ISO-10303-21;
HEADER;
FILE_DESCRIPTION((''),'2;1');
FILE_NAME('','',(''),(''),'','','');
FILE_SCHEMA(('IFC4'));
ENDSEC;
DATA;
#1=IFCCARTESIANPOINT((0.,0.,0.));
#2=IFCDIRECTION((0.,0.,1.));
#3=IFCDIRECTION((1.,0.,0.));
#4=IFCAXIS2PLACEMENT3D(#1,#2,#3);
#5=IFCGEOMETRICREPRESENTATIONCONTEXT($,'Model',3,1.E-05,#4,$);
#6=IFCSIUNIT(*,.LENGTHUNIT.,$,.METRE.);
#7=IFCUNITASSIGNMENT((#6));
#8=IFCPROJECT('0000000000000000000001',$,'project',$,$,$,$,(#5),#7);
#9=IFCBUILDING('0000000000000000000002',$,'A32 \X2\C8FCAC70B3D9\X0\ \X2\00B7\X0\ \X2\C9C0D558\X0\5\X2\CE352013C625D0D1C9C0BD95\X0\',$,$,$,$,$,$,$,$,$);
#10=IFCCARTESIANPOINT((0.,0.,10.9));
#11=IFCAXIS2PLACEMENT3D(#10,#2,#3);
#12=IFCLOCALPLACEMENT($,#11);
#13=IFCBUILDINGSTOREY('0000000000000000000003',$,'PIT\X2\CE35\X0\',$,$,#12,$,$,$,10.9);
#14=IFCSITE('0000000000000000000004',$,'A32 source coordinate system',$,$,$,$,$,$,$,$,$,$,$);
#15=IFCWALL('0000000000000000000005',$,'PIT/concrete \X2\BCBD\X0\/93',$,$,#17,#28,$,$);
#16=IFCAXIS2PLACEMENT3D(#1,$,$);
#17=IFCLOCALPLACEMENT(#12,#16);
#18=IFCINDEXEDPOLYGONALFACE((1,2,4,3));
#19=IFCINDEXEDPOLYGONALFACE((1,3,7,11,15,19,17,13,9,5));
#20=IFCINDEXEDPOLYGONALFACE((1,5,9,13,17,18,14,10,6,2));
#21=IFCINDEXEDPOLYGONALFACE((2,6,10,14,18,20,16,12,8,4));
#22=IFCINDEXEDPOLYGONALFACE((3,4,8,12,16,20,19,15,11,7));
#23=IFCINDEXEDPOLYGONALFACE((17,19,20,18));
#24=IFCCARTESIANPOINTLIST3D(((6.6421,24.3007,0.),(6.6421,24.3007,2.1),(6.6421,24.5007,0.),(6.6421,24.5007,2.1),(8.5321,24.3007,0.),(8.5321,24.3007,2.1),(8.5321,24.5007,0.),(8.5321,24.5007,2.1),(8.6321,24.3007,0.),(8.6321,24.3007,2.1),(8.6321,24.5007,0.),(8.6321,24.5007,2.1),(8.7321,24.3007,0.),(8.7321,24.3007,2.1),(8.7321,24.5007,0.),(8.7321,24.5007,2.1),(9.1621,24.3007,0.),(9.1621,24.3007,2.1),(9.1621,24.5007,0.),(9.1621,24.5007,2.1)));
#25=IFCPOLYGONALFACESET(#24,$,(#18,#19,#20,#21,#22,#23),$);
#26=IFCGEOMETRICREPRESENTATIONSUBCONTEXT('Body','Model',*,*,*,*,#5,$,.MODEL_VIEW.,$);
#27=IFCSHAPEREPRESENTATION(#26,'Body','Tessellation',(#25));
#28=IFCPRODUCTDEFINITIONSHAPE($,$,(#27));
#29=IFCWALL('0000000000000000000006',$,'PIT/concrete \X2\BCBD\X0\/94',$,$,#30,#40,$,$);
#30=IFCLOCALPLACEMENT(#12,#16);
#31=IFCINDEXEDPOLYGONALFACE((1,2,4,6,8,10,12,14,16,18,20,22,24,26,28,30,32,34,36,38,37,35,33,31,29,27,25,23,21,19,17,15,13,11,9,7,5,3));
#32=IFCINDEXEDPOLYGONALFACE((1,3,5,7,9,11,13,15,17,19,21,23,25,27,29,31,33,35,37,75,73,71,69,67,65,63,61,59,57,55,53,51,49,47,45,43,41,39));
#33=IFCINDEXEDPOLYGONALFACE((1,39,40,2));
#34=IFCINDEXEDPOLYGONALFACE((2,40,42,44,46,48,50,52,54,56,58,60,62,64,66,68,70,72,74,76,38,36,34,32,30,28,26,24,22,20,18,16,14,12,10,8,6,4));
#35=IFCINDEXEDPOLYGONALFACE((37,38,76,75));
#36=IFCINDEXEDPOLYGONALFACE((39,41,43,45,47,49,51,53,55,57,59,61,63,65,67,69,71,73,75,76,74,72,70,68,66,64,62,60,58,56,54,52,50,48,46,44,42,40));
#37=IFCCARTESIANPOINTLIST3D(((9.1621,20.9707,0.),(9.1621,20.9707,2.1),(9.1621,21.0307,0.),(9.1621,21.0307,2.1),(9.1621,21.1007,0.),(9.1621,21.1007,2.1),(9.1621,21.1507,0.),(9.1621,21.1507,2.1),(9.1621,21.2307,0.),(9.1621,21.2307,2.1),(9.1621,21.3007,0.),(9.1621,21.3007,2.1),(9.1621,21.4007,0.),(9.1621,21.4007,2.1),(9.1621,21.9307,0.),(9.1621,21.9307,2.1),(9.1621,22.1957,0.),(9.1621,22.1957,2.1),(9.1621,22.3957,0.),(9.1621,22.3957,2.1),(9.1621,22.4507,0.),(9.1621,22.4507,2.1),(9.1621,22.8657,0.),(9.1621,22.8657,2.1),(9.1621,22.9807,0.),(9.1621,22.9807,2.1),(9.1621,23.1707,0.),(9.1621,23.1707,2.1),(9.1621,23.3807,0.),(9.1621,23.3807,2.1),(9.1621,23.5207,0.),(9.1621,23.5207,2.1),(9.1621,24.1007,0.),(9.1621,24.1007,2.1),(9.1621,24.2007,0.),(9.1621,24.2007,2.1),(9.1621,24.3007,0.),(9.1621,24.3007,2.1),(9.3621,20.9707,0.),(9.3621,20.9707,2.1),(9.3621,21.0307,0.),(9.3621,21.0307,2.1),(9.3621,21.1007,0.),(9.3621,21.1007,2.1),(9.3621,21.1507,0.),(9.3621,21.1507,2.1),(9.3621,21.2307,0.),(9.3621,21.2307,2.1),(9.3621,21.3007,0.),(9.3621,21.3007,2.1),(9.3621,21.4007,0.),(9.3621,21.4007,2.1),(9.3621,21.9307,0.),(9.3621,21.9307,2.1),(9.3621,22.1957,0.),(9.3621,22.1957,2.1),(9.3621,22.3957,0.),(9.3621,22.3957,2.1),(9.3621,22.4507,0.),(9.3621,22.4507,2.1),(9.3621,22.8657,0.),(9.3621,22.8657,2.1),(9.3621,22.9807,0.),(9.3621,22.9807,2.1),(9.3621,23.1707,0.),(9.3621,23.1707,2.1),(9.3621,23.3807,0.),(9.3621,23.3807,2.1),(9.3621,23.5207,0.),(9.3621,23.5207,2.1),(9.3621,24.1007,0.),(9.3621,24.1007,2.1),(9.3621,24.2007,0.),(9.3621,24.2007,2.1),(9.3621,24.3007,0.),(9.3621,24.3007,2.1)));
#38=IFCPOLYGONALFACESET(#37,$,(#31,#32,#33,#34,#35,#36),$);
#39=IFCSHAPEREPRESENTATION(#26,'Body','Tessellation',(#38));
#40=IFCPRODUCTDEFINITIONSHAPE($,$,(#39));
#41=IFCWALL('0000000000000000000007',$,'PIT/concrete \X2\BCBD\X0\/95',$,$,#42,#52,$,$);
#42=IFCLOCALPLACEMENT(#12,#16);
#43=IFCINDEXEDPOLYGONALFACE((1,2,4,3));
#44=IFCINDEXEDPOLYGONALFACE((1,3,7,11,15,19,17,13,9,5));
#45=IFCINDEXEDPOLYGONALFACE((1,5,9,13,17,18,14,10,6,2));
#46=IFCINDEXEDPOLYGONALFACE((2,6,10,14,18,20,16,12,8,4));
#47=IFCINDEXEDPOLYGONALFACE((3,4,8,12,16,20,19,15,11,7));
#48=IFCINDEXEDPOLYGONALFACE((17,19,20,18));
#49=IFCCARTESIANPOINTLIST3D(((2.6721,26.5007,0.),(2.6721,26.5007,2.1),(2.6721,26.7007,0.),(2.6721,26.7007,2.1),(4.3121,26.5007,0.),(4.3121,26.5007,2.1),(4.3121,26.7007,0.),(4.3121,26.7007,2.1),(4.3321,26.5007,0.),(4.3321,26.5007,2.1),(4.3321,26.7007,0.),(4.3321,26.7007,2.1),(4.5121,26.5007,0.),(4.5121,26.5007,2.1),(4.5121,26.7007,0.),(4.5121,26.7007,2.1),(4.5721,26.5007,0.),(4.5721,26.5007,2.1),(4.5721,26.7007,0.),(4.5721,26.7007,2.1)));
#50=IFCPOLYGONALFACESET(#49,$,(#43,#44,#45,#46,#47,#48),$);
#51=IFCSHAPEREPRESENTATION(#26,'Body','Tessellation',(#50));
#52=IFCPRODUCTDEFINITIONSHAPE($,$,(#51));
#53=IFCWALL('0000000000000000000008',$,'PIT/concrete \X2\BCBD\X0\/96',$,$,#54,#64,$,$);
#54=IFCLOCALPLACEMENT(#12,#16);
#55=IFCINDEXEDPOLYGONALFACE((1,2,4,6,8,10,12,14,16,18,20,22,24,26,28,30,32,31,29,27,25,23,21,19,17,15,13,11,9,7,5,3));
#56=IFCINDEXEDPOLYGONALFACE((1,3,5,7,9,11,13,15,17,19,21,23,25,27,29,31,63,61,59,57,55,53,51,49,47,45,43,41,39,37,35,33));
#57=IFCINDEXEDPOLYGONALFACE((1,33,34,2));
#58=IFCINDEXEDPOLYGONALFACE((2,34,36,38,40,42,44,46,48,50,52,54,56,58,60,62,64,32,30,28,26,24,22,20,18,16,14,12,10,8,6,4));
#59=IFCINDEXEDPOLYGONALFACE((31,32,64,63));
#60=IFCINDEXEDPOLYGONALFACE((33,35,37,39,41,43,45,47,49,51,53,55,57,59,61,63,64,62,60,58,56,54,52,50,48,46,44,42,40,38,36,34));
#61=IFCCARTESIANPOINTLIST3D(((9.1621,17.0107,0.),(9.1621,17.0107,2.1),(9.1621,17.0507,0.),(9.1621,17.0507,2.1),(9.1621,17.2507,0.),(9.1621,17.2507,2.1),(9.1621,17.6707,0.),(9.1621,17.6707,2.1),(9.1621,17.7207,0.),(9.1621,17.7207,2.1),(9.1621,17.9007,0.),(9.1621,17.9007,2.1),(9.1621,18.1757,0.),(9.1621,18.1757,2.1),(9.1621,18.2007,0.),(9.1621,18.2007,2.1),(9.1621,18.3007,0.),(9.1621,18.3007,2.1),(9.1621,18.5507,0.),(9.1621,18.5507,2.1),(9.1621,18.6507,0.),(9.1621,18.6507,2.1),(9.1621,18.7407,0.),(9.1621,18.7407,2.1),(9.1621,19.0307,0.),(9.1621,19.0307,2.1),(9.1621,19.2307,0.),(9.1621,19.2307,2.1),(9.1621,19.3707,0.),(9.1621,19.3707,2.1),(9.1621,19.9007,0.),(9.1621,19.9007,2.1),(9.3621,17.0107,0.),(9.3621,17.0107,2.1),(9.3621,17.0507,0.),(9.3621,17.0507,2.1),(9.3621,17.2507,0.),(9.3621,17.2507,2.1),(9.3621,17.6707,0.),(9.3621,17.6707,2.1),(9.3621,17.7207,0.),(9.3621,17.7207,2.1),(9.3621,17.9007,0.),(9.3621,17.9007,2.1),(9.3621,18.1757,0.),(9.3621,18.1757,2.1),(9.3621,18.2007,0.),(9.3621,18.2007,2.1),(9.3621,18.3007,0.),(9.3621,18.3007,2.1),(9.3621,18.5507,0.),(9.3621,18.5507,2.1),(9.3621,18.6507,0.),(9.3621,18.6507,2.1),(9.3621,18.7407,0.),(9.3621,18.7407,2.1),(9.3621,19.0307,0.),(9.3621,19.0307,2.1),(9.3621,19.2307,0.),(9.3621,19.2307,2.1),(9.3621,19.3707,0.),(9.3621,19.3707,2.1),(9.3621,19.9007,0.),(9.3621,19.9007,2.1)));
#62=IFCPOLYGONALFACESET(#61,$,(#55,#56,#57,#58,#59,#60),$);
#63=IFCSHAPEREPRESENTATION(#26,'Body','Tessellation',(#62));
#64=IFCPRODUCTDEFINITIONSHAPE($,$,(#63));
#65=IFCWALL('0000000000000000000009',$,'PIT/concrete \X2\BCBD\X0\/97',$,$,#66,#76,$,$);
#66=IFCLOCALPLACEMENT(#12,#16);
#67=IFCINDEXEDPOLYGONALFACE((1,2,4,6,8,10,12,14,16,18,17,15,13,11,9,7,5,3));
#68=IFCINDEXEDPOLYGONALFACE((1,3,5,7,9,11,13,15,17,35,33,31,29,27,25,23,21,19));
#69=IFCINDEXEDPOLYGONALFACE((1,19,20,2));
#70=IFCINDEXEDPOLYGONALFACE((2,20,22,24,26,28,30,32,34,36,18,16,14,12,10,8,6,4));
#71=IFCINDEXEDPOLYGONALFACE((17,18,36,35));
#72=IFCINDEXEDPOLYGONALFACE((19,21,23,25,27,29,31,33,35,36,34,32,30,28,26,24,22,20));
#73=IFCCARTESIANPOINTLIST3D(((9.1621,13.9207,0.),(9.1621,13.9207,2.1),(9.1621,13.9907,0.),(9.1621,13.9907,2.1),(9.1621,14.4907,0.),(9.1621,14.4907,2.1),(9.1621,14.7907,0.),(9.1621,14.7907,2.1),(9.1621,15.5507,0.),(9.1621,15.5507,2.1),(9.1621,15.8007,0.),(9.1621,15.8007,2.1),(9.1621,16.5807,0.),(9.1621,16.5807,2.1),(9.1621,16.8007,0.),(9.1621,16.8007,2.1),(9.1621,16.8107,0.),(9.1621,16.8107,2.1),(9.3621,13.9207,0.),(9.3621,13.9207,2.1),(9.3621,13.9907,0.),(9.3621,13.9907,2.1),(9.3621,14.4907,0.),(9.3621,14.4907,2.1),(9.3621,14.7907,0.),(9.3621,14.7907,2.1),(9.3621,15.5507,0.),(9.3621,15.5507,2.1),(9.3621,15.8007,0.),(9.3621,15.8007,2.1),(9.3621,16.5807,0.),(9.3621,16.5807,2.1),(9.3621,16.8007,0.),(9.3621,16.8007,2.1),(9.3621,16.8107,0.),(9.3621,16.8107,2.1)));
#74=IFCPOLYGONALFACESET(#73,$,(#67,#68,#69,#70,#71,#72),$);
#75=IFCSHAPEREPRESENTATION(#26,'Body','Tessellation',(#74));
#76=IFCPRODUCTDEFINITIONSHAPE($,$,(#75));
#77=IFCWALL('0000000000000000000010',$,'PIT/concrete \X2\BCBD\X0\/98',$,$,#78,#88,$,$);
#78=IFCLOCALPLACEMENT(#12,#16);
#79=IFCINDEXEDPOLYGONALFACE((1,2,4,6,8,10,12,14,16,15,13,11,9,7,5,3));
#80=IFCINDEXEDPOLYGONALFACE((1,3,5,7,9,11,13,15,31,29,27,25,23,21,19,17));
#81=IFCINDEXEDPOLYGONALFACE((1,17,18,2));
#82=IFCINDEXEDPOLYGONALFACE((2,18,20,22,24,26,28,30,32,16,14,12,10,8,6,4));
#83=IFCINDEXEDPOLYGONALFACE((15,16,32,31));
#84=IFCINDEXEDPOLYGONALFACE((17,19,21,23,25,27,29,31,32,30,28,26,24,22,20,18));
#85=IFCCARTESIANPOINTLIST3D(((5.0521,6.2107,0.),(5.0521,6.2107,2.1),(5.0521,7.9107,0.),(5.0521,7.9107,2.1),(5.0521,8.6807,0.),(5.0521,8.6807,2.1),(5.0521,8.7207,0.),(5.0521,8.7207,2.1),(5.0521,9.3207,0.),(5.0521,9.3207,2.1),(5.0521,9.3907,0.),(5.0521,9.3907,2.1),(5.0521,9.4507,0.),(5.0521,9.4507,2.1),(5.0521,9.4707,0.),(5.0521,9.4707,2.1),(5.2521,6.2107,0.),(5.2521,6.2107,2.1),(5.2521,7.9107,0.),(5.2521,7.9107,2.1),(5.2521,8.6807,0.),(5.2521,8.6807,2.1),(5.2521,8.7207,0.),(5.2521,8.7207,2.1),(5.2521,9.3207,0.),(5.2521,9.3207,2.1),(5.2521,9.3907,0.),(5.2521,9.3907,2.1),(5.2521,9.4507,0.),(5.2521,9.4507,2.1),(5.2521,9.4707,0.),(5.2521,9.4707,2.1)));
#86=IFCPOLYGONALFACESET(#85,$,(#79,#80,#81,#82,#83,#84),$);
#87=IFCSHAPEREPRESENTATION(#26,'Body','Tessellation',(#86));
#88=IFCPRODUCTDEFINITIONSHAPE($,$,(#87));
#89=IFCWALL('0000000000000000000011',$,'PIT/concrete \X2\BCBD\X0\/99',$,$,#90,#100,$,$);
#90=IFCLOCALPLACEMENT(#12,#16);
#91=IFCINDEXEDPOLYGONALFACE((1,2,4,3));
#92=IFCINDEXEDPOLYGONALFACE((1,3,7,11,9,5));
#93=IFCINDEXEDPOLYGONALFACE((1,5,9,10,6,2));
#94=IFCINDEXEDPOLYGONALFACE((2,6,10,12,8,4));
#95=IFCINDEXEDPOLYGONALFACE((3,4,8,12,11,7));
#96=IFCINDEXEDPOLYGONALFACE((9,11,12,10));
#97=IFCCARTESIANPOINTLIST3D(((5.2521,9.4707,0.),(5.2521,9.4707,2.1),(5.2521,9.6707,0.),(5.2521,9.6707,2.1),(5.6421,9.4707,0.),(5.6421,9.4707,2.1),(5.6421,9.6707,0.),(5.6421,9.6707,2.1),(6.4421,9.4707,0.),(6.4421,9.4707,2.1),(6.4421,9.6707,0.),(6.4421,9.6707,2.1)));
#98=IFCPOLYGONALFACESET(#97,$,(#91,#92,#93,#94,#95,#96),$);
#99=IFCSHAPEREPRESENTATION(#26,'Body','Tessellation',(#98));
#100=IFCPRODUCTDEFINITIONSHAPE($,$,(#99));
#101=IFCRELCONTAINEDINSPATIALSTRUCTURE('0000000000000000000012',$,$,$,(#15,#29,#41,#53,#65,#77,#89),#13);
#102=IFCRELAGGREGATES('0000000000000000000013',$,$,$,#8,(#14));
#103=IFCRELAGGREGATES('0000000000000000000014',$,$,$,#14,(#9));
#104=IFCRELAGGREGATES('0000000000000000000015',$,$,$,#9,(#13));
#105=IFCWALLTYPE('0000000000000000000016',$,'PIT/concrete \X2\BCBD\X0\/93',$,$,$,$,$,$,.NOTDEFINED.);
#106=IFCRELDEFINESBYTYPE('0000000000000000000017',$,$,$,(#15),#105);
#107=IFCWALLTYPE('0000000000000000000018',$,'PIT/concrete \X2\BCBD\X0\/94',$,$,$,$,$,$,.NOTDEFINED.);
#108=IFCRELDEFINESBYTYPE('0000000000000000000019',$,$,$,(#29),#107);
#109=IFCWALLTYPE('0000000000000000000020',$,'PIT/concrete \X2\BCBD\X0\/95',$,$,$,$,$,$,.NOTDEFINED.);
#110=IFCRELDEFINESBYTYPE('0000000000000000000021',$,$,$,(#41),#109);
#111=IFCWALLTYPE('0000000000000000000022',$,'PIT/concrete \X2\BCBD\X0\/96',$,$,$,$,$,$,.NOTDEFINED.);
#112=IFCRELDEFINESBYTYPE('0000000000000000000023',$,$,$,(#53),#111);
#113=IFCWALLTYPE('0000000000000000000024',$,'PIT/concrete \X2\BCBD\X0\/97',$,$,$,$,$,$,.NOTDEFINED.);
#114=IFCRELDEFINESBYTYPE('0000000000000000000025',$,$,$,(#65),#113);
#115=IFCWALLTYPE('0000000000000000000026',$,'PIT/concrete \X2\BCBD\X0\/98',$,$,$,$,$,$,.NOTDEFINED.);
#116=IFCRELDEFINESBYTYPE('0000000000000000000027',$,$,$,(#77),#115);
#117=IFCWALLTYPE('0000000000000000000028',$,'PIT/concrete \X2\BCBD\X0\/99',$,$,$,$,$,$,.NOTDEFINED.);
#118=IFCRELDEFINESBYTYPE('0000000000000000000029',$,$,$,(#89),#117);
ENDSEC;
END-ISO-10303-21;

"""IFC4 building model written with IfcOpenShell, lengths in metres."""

from ifc_helpers import new_model, si_unit, frame, origin, origin_with_axes, place, context, subcontext, project, spatial, polyline, outline, extrude, source, transform, mapped, type_object, type_shapes, element, save


model = new_model("IFC4")

# Units and contexts
model_context = context("Model", 3, precision=1e-05, world=origin_with_axes())
body_context = subcontext(model_context, "Body", "Model", "MODEL_VIEW")
ifc_project = project(units=[si_unit("LENGTHUNIT", "METRE")], contexts=[model_context])

# Site, building, storey
site = spatial("IfcSite", under=ifc_project, Name="A32 source coordinate system")
building = spatial("IfcBuilding", under=site, Name="A32 주거동 · 지하5층–옥탑지붕")
storey_placement = place(None, frame((0.0, 0.0, 10.9), z_axis=(0.0, 0.0, 1.0), x_axis=(1.0, 0.0, 0.0)))
storey = spatial("IfcBuildingStorey", under=building, at=storey_placement, Name="PIT층", Elevation=10.9)

# Walls
wall_type_1 = type_object("IfcWallType", Name="PIT/concrete 벽/93", PredefinedType="NOTDEFINED")
shared_shape_1 = source(origin(), body_context, "Body", "SweptSolid", [
    extrude(outline(polyline([(8.6321, 24.5007), (8.7321, 24.5007), (9.1621, 24.5007), (9.1621, 24.3007), (8.7321, 24.3007), (8.6321, 24.3007), (8.5321, 24.3007), (6.6421, 24.3007), (6.6421, 24.5007), (8.5321, 24.5007), (8.6321, 24.5007)])), origin(), (0.0, 0.0, 1.0), 2.1),
])
type_shapes(wall_type_1, [shared_shape_1])
wall_1_placement = place(storey_placement, origin_with_axes())
element("IfcWall", 1, at=wall_1_placement, inside=storey, type_object=wall_type_1, Name="PIT/concrete 벽/93", context=body_context, shape_type="MappedRepresentation", body=[
    mapped(shared_shape_1, transform((0.0, 0.0, 0.0), scale=1.0)),
])
wall_type_2 = type_object("IfcWallType", Name="PIT/concrete 벽/94", PredefinedType="NOTDEFINED")
shared_shape_2 = source(origin(), body_context, "Body", "SweptSolid", [
    extrude(outline(polyline([(9.3621, 24.1007), (9.3621, 23.5207), (9.3621, 23.3807), (9.3621, 23.1707), (9.3621, 22.9807), (9.3621, 22.8657), (9.3621, 22.4507), (9.3621, 22.3957), (9.3621, 22.1957), (9.3621, 21.9307), (9.3621, 21.4007), (9.3621, 21.3007), (9.3621, 21.2307), (9.3621, 21.1507), (9.3621, 21.1007), (9.3621, 21.0307), (9.3621, 20.9707), (9.1621, 20.9707), (9.1621, 21.0307), (9.1621, 21.1007), (9.1621, 21.1507), (9.1621, 21.2307), (9.1621, 21.3007), (9.1621, 21.4007), (9.1621, 21.9307), (9.1621, 22.1957), (9.1621, 22.3957), (9.1621, 22.4507), (9.1621, 22.8657), (9.1621, 22.9807), (9.1621, 23.1707), (9.1621, 23.3807), (9.1621, 23.5207), (9.1621, 24.1007), (9.1621, 24.2007), (9.1621, 24.3007), (9.3621, 24.3007), (9.3621, 24.2007), (9.3621, 24.1007)])), origin(), (0.0, 0.0, 1.0), 2.1),
])
type_shapes(wall_type_2, [shared_shape_2])
wall_2_placement = place(storey_placement, origin_with_axes())
element("IfcWall", 2, at=wall_2_placement, inside=storey, type_object=wall_type_2, Name="PIT/concrete 벽/94", context=body_context, shape_type="MappedRepresentation", body=[
    mapped(shared_shape_2, transform((0.0, 0.0, 0.0), scale=1.0)),
])
wall_type_3 = type_object("IfcWallType", Name="PIT/concrete 벽/95", PredefinedType="NOTDEFINED")
shared_shape_3 = source(origin(), body_context, "Body", "SweptSolid", [
    extrude(outline(polyline([(4.3321, 26.7007), (4.5121, 26.7007), (4.5721, 26.7007), (4.5721, 26.5007), (4.5121, 26.5007), (4.3321, 26.5007), (4.3121, 26.5007), (2.6721, 26.5007), (2.6721, 26.7007), (4.3121, 26.7007), (4.3321, 26.7007)])), origin(), (0.0, 0.0, 1.0), 2.1),
])
type_shapes(wall_type_3, [shared_shape_3])
wall_3_placement = place(storey_placement, origin_with_axes())
element("IfcWall", 3, at=wall_3_placement, inside=storey, type_object=wall_type_3, Name="PIT/concrete 벽/95", context=body_context, shape_type="MappedRepresentation", body=[
    mapped(shared_shape_3, transform((0.0, 0.0, 0.0), scale=1.0)),
])
wall_type_4 = type_object("IfcWallType", Name="PIT/concrete 벽/96", PredefinedType="NOTDEFINED")
shared_shape_4 = source(origin(), body_context, "Body", "SweptSolid", [
    extrude(outline(polyline([(9.1621, 17.6707), (9.1621, 17.7207), (9.1621, 17.9007), (9.1621, 18.1757), (9.1621, 18.2007), (9.1621, 18.3007), (9.1621, 18.5507), (9.1621, 18.6507), (9.1621, 18.7407), (9.1621, 19.0307), (9.1621, 19.2307), (9.1621, 19.3707), (9.1621, 19.9007), (9.3621, 19.9007), (9.3621, 19.3707), (9.3621, 19.2307), (9.3621, 19.0307), (9.3621, 18.7407), (9.3621, 18.6507), (9.3621, 18.5507), (9.3621, 18.3007), (9.3621, 18.2007), (9.3621, 18.1757), (9.3621, 17.9007), (9.3621, 17.7207), (9.3621, 17.6707), (9.3621, 17.2507), (9.3621, 17.0507), (9.3621, 17.0107), (9.1621, 17.0107), (9.1621, 17.0507), (9.1621, 17.2507), (9.1621, 17.6707)])), origin(), (0.0, 0.0, 1.0), 2.1),
])
type_shapes(wall_type_4, [shared_shape_4])
wall_4_placement = place(storey_placement, origin_with_axes())
element("IfcWall", 4, at=wall_4_placement, inside=storey, type_object=wall_type_4, Name="PIT/concrete 벽/96", context=body_context, shape_type="MappedRepresentation", body=[
    mapped(shared_shape_4, transform((0.0, 0.0, 0.0), scale=1.0)),
])
wall_type_5 = type_object("IfcWallType", Name="PIT/concrete 벽/97", PredefinedType="NOTDEFINED")
shared_shape_5 = source(origin(), body_context, "Body", "SweptSolid", [
    extrude(outline(polyline([(9.3621, 16.5807), (9.3621, 15.8007), (9.3621, 15.5507), (9.3621, 14.7907), (9.3621, 14.4907), (9.3621, 13.9907), (9.3621, 13.9207), (9.1621, 13.9207), (9.1621, 13.9907), (9.1621, 14.4907), (9.1621, 14.7907), (9.1621, 15.5507), (9.1621, 15.8007), (9.1621, 16.5807), (9.1621, 16.8007), (9.1621, 16.8107), (9.3621, 16.8107), (9.3621, 16.8007), (9.3621, 16.5807)])), origin(), (0.0, 0.0, 1.0), 2.1),
])
type_shapes(wall_type_5, [shared_shape_5])
wall_5_placement = place(storey_placement, origin_with_axes())
element("IfcWall", 5, at=wall_5_placement, inside=storey, type_object=wall_type_5, Name="PIT/concrete 벽/97", context=body_context, shape_type="MappedRepresentation", body=[
    mapped(shared_shape_5, transform((0.0, 0.0, 0.0), scale=1.0)),
])
wall_type_6 = type_object("IfcWallType", Name="PIT/concrete 벽/98", PredefinedType="NOTDEFINED")
shared_shape_6 = source(origin(), body_context, "Body", "SweptSolid", [
    extrude(outline(polyline([(5.2521, 9.3907), (5.2521, 9.3207), (5.2521, 8.7207), (5.2521, 8.6807), (5.2521, 7.9107), (5.2521, 6.2107), (5.0521, 6.2107), (5.0521, 7.9107), (5.0521, 8.6807), (5.0521, 8.7207), (5.0521, 9.3207), (5.0521, 9.3907), (5.0521, 9.4507), (5.0521, 9.4707), (5.2521, 9.4707), (5.2521, 9.4507), (5.2521, 9.3907)])), origin(), (0.0, 0.0, 1.0), 2.1),
])
type_shapes(wall_type_6, [shared_shape_6])
wall_6_placement = place(storey_placement, origin_with_axes())
element("IfcWall", 6, at=wall_6_placement, inside=storey, type_object=wall_type_6, Name="PIT/concrete 벽/98", context=body_context, shape_type="MappedRepresentation", body=[
    mapped(shared_shape_6, transform((0.0, 0.0, 0.0), scale=1.0)),
])
wall_type_7 = type_object("IfcWallType", Name="PIT/concrete 벽/99", PredefinedType="NOTDEFINED")
shared_shape_7 = source(origin(), body_context, "Body", "SweptSolid", [
    extrude(outline(polyline([(6.4421, 9.6707), (6.4421, 9.4707), (5.6421, 9.4707), (5.2521, 9.4707), (5.2521, 9.6707), (5.6421, 9.6707), (6.4421, 9.6707)])), origin(), (0.0, 0.0, 1.0), 2.1),
])
type_shapes(wall_type_7, [shared_shape_7])
wall_7_placement = place(storey_placement, origin_with_axes())
element("IfcWall", 7, at=wall_7_placement, inside=storey, type_object=wall_type_7, Name="PIT/concrete 벽/99", context=body_context, shape_type="MappedRepresentation", body=[
    mapped(shared_shape_7, transform((0.0, 0.0, 0.0), scale=1.0)),
])

save(model, "model.ifc")
